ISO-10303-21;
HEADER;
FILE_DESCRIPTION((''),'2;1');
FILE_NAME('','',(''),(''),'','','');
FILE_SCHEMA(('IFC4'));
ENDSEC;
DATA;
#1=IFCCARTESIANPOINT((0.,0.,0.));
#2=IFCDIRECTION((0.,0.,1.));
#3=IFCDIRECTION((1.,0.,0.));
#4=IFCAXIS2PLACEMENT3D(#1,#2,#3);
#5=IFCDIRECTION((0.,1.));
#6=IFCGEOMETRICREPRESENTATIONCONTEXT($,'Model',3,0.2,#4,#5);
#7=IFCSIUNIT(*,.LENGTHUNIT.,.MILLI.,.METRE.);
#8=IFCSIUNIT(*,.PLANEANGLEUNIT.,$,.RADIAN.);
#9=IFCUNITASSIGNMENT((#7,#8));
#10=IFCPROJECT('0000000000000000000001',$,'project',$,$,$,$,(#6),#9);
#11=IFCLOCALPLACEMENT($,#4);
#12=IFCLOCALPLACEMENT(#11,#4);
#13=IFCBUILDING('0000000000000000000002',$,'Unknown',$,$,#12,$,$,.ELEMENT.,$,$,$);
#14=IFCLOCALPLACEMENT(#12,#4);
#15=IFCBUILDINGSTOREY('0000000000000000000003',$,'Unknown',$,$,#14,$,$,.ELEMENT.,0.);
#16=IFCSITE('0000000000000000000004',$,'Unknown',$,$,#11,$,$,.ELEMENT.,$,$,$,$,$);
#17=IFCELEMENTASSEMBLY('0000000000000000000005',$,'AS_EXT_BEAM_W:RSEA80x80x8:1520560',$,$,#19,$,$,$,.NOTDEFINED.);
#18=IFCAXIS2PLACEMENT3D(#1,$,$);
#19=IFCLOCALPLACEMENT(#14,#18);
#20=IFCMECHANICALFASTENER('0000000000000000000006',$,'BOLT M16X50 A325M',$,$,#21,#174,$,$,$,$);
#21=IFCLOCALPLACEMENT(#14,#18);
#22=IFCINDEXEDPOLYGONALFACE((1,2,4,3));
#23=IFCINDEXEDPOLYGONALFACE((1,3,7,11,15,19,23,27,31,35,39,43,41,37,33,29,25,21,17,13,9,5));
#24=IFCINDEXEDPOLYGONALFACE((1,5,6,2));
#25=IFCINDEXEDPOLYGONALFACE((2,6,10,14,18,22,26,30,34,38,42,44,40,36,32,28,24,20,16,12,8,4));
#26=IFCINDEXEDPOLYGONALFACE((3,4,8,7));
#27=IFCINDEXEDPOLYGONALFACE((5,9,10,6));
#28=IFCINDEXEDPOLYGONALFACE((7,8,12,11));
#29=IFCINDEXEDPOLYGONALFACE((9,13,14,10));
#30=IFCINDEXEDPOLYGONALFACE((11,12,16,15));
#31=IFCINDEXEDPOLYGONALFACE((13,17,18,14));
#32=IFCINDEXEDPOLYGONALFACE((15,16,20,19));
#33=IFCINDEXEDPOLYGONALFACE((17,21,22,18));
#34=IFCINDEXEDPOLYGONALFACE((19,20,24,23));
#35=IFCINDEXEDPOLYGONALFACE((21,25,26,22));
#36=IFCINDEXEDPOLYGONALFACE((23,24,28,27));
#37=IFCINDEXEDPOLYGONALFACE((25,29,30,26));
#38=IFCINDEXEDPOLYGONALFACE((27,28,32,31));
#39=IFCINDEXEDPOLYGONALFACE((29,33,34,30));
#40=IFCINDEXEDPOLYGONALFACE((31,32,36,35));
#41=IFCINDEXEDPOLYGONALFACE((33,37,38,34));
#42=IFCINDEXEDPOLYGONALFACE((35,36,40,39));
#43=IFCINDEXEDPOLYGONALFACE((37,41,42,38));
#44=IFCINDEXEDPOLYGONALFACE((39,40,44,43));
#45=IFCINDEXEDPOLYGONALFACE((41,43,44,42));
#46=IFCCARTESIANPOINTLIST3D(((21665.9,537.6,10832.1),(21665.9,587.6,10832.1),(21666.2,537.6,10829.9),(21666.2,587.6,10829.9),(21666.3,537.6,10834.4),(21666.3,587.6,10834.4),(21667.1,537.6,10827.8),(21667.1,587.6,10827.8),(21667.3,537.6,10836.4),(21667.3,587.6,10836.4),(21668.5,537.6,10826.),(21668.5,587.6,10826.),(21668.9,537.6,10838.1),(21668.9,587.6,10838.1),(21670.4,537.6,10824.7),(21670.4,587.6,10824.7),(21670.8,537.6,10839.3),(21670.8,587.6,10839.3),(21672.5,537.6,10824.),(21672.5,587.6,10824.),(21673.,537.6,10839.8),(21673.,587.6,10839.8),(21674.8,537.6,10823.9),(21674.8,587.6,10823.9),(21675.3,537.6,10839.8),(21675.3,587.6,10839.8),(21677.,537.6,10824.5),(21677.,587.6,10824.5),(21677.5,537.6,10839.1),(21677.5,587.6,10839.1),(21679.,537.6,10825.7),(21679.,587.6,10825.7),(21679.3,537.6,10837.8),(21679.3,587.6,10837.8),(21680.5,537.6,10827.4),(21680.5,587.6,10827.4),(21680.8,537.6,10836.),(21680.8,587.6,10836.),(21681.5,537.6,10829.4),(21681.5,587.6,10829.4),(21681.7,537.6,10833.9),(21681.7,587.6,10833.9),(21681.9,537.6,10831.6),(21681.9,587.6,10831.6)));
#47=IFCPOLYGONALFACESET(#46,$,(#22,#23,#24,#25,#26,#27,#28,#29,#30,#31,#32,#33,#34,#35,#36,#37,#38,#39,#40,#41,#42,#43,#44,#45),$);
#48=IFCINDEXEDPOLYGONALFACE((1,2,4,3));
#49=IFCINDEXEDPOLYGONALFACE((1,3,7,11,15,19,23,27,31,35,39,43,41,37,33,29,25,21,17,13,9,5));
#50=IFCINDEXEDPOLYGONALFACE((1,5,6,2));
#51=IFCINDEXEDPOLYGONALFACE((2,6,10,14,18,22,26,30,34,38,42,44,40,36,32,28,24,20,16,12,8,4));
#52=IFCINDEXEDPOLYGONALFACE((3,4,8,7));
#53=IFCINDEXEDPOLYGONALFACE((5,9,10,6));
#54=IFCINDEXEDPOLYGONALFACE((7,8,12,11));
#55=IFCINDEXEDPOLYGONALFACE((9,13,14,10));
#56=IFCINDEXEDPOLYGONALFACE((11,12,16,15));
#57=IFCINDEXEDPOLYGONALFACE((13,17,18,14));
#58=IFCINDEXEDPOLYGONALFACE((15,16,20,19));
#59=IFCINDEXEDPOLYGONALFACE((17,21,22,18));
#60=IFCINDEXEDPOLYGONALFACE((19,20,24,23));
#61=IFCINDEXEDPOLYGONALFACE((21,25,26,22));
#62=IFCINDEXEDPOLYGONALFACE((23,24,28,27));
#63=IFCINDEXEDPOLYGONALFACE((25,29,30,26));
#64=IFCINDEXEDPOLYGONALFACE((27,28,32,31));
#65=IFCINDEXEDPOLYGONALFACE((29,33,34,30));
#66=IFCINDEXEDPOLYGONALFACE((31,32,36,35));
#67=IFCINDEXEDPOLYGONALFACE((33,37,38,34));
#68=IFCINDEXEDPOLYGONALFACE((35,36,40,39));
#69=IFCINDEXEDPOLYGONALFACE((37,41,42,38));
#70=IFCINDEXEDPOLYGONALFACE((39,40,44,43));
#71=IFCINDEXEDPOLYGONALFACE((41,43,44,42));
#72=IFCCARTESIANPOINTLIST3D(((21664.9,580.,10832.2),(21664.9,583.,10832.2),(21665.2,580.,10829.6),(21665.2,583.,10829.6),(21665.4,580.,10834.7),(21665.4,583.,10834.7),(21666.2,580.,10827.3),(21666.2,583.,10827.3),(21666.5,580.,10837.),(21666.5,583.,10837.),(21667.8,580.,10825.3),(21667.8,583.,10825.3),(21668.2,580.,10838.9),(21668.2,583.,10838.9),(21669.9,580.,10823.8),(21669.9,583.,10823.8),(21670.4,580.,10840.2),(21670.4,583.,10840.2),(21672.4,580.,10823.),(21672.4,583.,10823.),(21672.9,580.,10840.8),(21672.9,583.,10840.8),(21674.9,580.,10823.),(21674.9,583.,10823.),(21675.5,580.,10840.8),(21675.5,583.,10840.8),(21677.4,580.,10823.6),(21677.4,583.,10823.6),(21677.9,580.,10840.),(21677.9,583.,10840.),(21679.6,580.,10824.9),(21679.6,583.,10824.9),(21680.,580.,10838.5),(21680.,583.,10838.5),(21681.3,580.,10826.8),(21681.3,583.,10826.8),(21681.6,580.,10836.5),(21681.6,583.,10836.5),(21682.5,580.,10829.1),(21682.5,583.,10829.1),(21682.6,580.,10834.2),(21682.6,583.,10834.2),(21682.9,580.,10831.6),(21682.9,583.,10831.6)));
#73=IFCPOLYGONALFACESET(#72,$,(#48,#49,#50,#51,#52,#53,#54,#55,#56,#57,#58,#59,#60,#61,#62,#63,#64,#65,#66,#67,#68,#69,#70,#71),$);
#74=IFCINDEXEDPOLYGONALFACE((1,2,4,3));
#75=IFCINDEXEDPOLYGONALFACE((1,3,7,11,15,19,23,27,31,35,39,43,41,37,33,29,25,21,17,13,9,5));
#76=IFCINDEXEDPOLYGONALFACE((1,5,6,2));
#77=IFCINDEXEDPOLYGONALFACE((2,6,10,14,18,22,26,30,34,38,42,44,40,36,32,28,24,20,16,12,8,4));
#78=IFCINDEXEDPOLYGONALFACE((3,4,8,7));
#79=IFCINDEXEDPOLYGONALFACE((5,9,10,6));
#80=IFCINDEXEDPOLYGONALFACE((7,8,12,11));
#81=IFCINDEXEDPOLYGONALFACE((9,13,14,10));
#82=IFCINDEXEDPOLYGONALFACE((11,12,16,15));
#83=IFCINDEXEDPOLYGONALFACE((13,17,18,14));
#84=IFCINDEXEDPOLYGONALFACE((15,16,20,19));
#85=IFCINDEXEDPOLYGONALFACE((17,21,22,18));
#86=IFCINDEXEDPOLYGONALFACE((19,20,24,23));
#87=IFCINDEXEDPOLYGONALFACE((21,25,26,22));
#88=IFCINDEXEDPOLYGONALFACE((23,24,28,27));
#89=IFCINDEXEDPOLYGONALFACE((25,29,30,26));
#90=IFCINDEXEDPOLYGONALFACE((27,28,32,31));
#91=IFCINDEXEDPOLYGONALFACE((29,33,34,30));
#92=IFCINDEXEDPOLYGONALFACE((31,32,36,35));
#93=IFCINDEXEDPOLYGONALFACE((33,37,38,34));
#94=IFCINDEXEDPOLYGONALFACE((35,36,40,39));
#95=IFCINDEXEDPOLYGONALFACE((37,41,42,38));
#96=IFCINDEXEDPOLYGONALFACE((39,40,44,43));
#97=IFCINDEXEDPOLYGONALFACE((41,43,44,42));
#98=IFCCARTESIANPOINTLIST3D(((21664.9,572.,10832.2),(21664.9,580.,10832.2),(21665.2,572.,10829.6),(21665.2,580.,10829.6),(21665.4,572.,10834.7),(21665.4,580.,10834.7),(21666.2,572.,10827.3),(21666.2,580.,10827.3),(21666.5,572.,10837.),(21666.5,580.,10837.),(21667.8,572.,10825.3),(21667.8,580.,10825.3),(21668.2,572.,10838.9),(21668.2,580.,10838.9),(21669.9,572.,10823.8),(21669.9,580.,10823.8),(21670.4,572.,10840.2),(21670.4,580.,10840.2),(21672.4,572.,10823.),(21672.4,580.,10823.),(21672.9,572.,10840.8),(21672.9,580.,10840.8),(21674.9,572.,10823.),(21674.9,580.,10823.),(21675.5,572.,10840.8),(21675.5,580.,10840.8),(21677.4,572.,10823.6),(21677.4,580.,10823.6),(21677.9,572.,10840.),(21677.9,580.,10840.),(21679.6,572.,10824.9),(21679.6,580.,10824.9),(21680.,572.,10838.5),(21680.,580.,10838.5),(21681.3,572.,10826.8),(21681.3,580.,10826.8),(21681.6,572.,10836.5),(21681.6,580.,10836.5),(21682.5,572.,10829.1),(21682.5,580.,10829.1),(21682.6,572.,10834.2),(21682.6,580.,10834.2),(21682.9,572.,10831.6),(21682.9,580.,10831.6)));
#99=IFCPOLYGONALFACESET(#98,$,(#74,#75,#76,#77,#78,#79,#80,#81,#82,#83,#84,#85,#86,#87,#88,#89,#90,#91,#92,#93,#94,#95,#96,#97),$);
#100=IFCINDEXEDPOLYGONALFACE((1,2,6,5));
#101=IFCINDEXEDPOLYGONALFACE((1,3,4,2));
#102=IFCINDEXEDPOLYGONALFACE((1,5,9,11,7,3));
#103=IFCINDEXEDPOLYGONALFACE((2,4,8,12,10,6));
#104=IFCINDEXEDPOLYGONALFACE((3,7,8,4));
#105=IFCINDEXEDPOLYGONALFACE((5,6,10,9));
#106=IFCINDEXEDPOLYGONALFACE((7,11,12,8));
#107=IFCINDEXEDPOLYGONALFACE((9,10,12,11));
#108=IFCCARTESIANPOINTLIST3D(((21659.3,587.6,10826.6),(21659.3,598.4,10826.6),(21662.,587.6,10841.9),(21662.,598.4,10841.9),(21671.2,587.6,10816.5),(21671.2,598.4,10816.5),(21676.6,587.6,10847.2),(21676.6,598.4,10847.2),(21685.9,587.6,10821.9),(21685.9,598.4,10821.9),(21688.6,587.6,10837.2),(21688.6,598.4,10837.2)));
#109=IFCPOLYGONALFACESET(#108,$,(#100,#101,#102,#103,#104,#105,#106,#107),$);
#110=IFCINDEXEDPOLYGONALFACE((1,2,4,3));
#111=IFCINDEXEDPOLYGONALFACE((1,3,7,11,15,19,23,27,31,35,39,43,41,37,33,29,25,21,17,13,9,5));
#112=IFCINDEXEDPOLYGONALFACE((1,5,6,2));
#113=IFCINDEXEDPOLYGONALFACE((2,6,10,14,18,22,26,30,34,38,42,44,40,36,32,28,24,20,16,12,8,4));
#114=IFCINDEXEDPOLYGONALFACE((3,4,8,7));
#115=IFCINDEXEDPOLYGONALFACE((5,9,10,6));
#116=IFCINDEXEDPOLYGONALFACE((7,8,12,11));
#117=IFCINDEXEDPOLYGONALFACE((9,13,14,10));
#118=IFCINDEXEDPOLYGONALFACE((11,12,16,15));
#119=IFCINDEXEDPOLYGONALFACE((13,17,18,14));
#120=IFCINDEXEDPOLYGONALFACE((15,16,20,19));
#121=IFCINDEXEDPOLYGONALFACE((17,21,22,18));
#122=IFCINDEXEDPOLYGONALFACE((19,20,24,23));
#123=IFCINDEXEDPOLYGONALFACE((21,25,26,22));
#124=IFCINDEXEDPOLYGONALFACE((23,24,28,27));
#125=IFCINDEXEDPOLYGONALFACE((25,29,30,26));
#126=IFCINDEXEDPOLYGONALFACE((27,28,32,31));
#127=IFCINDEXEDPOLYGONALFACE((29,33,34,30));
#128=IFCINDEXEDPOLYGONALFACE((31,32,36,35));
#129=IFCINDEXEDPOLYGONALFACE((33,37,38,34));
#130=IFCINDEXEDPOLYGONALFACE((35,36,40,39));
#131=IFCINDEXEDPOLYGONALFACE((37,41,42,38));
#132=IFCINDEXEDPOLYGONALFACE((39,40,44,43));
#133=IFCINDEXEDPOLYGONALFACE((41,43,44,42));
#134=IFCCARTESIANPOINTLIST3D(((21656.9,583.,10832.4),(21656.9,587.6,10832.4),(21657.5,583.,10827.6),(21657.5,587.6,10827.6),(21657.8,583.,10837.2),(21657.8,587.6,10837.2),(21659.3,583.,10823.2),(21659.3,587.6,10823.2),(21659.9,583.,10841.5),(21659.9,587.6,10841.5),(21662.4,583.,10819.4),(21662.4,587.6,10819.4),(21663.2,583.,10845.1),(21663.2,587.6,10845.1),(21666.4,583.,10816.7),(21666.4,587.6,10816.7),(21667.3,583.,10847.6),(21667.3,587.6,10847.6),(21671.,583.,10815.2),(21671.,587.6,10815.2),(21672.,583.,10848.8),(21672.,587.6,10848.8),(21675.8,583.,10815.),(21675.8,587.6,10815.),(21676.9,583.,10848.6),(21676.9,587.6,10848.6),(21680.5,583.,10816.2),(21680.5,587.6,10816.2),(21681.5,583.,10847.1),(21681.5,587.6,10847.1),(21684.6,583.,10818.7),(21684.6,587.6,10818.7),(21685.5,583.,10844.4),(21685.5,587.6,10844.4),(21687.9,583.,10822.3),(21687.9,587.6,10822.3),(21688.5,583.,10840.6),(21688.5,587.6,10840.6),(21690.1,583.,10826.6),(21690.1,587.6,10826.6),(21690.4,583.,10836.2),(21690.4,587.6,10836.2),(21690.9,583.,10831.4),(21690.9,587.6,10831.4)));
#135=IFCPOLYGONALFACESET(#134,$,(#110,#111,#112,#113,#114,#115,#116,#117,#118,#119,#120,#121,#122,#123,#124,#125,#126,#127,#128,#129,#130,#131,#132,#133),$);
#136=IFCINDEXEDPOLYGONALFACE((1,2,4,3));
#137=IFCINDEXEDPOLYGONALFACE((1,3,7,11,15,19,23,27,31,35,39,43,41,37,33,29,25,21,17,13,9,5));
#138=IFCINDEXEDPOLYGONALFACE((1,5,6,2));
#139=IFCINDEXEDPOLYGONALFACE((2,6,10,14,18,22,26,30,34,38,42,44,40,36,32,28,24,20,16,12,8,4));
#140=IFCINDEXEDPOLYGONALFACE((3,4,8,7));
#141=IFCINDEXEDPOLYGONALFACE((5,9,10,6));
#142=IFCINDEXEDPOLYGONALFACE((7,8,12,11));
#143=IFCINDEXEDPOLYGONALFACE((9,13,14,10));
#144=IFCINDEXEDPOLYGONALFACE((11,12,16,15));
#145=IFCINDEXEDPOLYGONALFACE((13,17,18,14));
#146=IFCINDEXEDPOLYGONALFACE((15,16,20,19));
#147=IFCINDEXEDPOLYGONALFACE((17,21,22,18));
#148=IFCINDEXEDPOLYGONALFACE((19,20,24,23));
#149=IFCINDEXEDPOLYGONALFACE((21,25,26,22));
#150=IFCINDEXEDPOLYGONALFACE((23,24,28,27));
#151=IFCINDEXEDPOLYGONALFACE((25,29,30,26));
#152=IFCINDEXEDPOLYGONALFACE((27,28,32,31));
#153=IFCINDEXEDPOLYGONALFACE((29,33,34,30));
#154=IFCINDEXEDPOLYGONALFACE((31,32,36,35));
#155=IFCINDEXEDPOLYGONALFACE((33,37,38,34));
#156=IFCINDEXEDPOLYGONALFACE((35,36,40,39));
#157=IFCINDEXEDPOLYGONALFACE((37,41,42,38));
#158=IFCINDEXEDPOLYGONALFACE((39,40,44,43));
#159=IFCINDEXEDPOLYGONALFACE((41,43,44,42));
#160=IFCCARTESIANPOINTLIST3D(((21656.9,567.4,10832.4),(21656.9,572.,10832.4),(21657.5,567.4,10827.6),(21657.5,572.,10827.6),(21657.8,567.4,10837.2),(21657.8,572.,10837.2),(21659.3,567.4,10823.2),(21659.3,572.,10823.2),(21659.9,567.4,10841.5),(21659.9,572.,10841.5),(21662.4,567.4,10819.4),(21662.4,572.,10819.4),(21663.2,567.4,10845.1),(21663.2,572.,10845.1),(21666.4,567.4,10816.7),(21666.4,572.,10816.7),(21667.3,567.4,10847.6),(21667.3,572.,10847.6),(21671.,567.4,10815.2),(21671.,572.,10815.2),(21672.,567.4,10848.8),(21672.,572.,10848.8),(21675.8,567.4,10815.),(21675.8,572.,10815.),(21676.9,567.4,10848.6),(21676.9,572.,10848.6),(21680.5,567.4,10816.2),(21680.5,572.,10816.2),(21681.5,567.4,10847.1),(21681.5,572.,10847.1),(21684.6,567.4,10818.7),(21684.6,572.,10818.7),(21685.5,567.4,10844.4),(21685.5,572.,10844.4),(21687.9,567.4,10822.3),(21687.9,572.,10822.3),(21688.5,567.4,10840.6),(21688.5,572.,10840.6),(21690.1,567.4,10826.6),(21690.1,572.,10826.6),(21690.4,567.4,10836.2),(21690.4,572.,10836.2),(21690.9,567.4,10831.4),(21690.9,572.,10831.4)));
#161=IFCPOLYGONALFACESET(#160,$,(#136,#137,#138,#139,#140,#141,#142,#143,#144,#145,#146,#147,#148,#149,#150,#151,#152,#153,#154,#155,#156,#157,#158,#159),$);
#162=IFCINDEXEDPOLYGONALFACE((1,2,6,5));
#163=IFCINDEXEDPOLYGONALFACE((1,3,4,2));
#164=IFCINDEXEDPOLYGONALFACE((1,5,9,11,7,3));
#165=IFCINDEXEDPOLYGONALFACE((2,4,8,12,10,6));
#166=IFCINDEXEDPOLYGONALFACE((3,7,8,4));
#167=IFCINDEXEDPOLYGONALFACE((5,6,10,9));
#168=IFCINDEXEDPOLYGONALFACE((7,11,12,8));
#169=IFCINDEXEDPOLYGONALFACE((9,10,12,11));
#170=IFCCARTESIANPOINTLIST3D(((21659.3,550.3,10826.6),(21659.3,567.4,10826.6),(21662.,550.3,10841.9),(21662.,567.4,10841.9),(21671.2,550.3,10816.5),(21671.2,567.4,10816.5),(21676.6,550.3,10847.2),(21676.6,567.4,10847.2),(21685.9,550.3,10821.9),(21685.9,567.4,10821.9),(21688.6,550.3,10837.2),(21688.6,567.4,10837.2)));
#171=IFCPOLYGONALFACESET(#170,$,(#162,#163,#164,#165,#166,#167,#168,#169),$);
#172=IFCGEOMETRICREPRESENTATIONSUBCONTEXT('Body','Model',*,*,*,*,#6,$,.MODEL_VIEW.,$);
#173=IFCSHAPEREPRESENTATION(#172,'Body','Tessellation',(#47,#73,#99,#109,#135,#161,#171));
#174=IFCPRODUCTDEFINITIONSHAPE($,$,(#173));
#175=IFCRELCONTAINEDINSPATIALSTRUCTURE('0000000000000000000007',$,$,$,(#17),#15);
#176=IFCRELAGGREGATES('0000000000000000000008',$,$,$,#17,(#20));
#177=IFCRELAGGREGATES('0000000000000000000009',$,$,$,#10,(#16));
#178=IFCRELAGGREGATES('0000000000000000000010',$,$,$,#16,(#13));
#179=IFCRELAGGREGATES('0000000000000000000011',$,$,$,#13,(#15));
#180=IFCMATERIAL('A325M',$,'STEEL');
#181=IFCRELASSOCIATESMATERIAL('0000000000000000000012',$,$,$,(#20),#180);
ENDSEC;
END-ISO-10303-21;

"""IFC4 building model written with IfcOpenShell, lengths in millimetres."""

from ifc_helpers import new_model, si_unit, direction, frame, origin_with_axes, place, context, subcontext, project, spatial, line, arc, indexed_curve, outline, extrude, source, transform, mapped, material, element, aggregate, save


model = new_model("IFC4")

# Units and contexts
model_context = context("Model", 3, precision=0.2, world=origin_with_axes(), true_north=direction((0.0, 1.0)))
body_context = subcontext(model_context, "Body", "Model", "MODEL_VIEW")
ifc_project = project(units=[si_unit("LENGTHUNIT", "METRE", prefix="MILLI"), si_unit("PLANEANGLEUNIT", "RADIAN")], contexts=[model_context])

# Site, building, storey
site_placement = place(None, origin_with_axes())
site = spatial("IfcSite", under=ifc_project, at=site_placement, Name="Unknown", CompositionType="ELEMENT")
building_placement = place(site_placement, origin_with_axes())
building = spatial("IfcBuilding", under=site, at=building_placement, Name="Unknown", CompositionType="ELEMENT")
storey_placement = place(building_placement, origin_with_axes())
storey = spatial("IfcBuildingStorey", under=building, at=storey_placement, Name="Unknown", CompositionType="ELEMENT", Elevation=0.0)

# Shared definitions
ifc_material_1 = material(Name="A325M", Category="STEEL")
shared_shape = source(origin_with_axes(), body_context, "Body", "SweptSolid", [
    extrude(outline(indexed_curve([(8.0, 0.0), (0.0, 8.0), (-8.0, 0.0), (0.0, -8.0)], segments=[arc(1, 2, 3), arc(3, 4, 1)])), frame((0.0, 0.0, 15.6), z_axis=(0.0, 0.0, -1.0), x_axis=(0.0, 1.0, 0.0)), (0.0, 0.0, 1.0), 50.0),
    extrude(outline(indexed_curve([(9.0, 0.0), (0.0, 9.0), (-9.0, 0.0), (0.0, -9.0)], segments=[arc(1, 2, 3), arc(3, 4, 1)])), frame((0.0, 0.0, 11.0), z_axis=(0.0, 0.0, -1.0), x_axis=(0.0, 1.0, 0.0)), (0.0, 0.0, 1.0), 3.0),
    extrude(outline(indexed_curve([(9.0, 0.0), (0.0, 9.0), (-9.0, 0.0), (0.0, -9.0)], segments=[arc(1, 2, 3), arc(3, 4, 1)])), frame((0.0, 0.0, 8.0), z_axis=(0.0, 0.0, -1.0), x_axis=(0.0, 1.0, 0.0)), (0.0, 0.0, 1.0), 8.0),
    extrude(outline(indexed_curve([(15.6, 0.0), (7.8, 13.5), (-7.8, 13.5), (-15.6, 0.0), (-7.8, -13.5), (7.8, -13.5)], segments=[line(1, 2, 3, 4, 5, 6, 1)])), frame((0.0, 0.0, 26.4), z_axis=(0.0, 0.0, -1.0), x_axis=(0.0, 1.0, 0.0)), (0.0, 0.0, 1.0), 10.8),
    extrude(outline(indexed_curve([(17.0, 0.0), (0.0, 17.0), (-17.0, 0.0), (0.0, -17.0)], segments=[arc(1, 2, 3), arc(3, 4, 1)])), frame((0.0, 0.0, 15.6), z_axis=(0.0, 0.0, -1.0), x_axis=(0.0, 1.0, 0.0)), (0.0, 0.0, 1.0), 4.6),
    extrude(outline(indexed_curve([(17.0, 0.0), (0.0, 17.0), (-17.0, 0.0), (0.0, -17.0)], segments=[arc(1, 2, 3), arc(3, 4, 1)])), frame((0.0, 0.0, 0.0), z_axis=(0.0, 0.0, -1.0), x_axis=(0.0, 1.0, 0.0)), (0.0, 0.0, 1.0), 4.6),
    extrude(outline(indexed_curve([(15.6, 0.0), (7.8, 13.5), (-7.8, 13.5), (-15.6, 0.0), (-7.8, -13.5), (7.8, -13.5)], segments=[line(1, 2, 3, 4, 5, 6, 1)])), frame((0.0, 0.0, -4.6), z_axis=(0.0, 0.0, -1.0), x_axis=(0.0, 1.0, 0.0)), (0.0, 0.0, 1.0), 17.1),
])

# Element assembly, mechanical fastener
assembly_1_placement = place(storey_placement, frame((21611.5, 540.0, 10837.8), z_axis=(0.0, -1.0, 0.0), x_axis=(0.984808, 0.0, -0.173648)))
assembly_1 = element("IfcElementAssembly", 1, at=assembly_1_placement, inside=storey, Name="AS_EXT_BEAM_W:RSEA80x80x8:1520560", PredefinedType="NOTDEFINED")
mechanical_fastener_1_placement = place(assembly_1_placement, frame((62.5, 5.0, -32.0), z_axis=(0.0, 0.0, -1.0), x_axis=(1.0, 0.0, 0.0)))
mechanical_fastener_1 = element("IfcMechanicalFastener", 2, at=mechanical_fastener_1_placement, material=ifc_material_1, Name="BOLT M16X50 A325M", context=body_context, shape_type="MappedRepresentation", body=[
    mapped(shared_shape, transform((0.0, 0.0, 0.0))),
])
aggregate(assembly_1, [mechanical_fastener_1])

save(model, "model.ifc")
